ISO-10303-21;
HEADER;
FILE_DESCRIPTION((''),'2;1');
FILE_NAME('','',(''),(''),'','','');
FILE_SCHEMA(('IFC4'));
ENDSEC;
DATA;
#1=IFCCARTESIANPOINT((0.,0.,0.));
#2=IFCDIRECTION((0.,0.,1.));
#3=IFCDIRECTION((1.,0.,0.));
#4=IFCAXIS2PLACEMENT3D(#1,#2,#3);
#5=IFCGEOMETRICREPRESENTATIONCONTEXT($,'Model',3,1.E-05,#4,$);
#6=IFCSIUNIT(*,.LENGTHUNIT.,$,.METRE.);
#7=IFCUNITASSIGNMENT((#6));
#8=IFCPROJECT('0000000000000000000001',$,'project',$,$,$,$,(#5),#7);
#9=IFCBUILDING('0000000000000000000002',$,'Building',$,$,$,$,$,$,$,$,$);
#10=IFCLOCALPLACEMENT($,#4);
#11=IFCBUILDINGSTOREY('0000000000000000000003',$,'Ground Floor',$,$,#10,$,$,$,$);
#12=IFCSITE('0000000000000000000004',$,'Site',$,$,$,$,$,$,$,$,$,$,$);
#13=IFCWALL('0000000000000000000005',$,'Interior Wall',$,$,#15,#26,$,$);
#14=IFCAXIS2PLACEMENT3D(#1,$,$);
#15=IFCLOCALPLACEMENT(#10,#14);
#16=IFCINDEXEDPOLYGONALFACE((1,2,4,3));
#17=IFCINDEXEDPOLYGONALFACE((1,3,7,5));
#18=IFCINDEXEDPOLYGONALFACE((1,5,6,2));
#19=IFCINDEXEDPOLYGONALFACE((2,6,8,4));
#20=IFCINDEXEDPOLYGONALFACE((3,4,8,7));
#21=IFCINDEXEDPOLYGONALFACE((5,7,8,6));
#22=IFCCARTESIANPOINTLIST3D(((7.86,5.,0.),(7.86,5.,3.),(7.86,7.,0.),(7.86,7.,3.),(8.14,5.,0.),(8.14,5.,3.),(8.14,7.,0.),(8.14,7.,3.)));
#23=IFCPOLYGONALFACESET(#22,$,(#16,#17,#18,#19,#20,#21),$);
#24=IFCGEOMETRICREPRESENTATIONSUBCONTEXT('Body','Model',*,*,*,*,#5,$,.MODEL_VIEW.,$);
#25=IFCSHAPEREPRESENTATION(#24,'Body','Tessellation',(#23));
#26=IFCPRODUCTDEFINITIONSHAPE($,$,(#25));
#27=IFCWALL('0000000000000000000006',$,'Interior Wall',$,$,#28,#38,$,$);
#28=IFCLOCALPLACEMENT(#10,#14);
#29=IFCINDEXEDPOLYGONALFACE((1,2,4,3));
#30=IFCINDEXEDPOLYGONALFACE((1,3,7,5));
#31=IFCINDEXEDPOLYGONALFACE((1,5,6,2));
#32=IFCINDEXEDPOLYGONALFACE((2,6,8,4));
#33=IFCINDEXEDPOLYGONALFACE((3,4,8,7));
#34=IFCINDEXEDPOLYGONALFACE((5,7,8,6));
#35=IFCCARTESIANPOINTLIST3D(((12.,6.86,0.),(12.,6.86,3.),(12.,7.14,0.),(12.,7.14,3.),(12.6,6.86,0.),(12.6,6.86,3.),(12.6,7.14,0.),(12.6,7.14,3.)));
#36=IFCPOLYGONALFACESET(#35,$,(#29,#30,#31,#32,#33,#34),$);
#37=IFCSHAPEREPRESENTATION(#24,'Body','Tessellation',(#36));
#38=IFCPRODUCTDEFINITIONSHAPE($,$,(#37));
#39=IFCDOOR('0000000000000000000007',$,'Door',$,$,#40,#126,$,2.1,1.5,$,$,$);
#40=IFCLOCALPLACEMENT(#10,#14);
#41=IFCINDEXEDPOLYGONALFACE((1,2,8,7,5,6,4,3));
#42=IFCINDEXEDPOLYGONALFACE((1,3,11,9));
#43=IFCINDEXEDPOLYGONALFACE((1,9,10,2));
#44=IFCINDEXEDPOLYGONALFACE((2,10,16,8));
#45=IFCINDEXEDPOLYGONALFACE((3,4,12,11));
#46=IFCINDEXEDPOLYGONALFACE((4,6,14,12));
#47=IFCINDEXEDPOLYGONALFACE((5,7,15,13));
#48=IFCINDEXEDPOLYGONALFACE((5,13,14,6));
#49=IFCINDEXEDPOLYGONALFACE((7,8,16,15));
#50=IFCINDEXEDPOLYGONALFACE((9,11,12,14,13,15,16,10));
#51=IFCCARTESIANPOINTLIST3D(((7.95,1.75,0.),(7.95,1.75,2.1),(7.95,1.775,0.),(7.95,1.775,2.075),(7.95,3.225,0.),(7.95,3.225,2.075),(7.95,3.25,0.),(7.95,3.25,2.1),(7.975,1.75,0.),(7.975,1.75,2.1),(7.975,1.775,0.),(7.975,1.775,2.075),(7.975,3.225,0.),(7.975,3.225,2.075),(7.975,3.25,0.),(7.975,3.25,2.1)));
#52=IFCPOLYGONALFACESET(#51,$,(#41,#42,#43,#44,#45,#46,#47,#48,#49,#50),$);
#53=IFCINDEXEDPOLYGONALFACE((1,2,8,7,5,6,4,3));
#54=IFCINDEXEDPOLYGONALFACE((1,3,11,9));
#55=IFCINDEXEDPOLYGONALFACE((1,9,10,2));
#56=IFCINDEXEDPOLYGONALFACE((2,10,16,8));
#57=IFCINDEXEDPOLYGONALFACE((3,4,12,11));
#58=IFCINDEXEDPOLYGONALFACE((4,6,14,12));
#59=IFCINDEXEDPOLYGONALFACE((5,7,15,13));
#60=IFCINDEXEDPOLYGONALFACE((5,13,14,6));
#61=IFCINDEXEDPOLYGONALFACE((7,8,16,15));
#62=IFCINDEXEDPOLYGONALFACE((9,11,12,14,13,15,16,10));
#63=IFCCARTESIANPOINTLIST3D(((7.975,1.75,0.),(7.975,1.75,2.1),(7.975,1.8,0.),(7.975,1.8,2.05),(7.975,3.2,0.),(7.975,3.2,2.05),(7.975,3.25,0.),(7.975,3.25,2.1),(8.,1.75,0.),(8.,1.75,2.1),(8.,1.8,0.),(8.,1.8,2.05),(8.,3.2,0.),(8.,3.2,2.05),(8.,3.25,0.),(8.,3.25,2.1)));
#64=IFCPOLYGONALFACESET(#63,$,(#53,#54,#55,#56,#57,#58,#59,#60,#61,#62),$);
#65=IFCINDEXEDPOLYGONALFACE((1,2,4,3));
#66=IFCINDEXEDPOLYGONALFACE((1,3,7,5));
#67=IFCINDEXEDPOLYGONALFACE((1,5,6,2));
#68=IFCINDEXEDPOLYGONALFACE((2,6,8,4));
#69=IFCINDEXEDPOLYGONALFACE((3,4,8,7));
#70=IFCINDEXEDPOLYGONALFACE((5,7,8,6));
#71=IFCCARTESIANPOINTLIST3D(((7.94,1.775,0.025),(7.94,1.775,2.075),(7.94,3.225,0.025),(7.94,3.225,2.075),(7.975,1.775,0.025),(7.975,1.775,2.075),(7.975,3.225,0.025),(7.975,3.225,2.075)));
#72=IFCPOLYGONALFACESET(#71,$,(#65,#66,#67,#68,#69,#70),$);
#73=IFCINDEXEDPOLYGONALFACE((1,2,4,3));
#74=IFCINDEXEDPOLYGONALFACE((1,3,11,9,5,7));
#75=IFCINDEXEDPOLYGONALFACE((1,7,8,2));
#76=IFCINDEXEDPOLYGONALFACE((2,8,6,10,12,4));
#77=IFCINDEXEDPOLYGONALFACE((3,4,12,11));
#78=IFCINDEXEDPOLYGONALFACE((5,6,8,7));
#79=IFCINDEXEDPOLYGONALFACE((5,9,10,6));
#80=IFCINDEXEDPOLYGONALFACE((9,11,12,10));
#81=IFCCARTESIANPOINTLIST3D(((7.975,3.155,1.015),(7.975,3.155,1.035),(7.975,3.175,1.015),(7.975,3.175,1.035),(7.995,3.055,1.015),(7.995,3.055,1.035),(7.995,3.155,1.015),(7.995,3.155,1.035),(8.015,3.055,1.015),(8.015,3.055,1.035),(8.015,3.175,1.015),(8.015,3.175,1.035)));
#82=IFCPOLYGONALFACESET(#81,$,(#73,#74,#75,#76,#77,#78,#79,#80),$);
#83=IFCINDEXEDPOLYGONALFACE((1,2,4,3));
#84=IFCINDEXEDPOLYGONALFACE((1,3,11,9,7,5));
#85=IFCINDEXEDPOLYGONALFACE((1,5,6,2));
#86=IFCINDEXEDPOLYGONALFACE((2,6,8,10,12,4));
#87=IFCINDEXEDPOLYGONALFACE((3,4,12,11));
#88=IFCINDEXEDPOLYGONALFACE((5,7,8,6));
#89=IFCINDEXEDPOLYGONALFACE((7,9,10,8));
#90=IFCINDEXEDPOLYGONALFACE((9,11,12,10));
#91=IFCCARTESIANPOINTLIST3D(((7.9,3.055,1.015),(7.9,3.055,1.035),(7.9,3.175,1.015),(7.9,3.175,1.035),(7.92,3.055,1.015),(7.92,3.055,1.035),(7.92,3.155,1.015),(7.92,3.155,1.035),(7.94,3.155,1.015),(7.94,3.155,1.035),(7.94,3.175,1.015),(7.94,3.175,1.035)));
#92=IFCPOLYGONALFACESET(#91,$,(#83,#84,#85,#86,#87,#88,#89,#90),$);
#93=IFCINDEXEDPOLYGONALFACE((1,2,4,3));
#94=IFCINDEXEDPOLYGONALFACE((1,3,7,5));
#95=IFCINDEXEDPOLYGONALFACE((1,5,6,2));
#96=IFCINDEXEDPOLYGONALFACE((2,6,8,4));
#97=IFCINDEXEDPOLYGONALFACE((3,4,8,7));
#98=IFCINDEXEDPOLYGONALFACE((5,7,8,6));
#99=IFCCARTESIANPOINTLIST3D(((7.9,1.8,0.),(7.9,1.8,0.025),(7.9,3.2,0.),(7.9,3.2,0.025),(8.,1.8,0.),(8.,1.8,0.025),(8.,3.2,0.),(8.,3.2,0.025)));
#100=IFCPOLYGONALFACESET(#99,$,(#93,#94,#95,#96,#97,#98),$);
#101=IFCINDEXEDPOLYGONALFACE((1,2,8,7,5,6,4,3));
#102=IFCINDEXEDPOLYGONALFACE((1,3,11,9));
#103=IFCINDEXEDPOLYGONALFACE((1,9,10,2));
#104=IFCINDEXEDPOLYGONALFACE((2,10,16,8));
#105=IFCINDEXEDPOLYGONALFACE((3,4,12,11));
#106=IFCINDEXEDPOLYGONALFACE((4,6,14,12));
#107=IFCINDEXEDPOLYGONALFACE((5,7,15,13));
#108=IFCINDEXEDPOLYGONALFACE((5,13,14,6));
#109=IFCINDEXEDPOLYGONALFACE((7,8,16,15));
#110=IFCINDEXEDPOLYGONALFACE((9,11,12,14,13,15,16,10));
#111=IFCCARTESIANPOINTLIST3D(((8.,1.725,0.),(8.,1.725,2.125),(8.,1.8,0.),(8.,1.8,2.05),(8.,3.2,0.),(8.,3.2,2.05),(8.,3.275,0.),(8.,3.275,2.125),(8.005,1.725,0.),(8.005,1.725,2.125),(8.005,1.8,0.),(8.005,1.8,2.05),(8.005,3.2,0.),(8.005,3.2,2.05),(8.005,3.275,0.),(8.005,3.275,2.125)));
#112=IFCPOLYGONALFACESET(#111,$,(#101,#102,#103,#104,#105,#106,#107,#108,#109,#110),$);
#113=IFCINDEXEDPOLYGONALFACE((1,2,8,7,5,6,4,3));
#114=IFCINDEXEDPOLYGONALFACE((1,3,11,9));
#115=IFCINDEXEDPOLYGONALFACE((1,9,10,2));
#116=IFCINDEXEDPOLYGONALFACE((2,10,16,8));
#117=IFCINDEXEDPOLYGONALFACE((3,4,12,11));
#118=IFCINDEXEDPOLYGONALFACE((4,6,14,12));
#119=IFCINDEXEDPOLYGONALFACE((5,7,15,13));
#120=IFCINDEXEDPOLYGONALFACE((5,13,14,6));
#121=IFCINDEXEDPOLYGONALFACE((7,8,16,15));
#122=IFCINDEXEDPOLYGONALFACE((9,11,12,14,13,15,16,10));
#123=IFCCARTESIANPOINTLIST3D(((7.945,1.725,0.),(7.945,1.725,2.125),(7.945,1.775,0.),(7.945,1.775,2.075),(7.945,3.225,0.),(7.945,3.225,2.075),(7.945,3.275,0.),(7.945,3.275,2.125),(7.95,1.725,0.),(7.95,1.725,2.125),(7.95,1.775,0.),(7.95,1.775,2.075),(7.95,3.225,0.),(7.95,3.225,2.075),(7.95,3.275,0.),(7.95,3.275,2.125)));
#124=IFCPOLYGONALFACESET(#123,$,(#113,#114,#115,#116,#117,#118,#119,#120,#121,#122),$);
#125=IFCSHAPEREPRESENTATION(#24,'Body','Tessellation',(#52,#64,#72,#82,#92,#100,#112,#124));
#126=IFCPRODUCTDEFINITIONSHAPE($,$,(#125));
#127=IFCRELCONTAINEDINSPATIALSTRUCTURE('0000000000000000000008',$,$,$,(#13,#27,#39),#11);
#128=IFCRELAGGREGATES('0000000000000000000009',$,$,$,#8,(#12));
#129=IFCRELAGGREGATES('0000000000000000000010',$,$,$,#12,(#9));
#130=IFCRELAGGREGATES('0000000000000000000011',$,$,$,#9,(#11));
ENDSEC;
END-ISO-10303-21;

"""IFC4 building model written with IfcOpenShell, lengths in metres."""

from ifc_helpers import new_model, si_unit, frame, origin_with_axes, place, context, subcontext, project, spatial, line, indexed_curve, outline, extrude, element, save


model = new_model("IFC4")

# Units and contexts
model_context = context("Model", 3, precision=1e-05, world=origin_with_axes())
body_context = subcontext(model_context, "Body", "Model", "MODEL_VIEW")
ifc_project = project(units=[si_unit("LENGTHUNIT", "METRE")], contexts=[model_context])

# Site, building, storey
site = spatial("IfcSite", under=ifc_project, Name="Site")
building = spatial("IfcBuilding", under=site, Name="Building")
storey_placement = place(None, origin_with_axes())
storey = spatial("IfcBuildingStorey", under=building, at=storey_placement, Name="Ground Floor")

# Walls
wall_1_placement = place(storey_placement, frame((8.0, 7.0, 0.0), z_axis=(0.0, 0.0, 1.0), x_axis=(0.0, -1.0, 0.0)))
element("IfcWall", 1, at=wall_1_placement, inside=storey, Name="Interior Wall", context=body_context, shape_type="SweptSolid", body=[
    extrude(outline(indexed_curve([(0.0, 0.0), (0.0, 0.28), (2.0, 0.28), (2.0, 0.0), (0.0, 0.0)], self_intersect=False)), frame((0.0, -0.14, 0.0), z_axis=(0.0, 0.0, 1.0), x_axis=(1.0, 0.0, 0.0)), (0.0, 0.0, 1.0), 3.0),
])
wall_2_placement = place(storey_placement, frame((12.6, 7.0, 0.0), z_axis=(0.0, 0.0, 1.0), x_axis=(-1.0, 0.0, 0.0)))
element("IfcWall", 2, at=wall_2_placement, inside=storey, Name="Interior Wall", context=body_context, shape_type="SweptSolid", body=[
    extrude(outline(indexed_curve([(0.0, 0.0), (0.0, 0.28), (0.6, 0.28), (0.6, 0.0), (0.0, 0.0)], self_intersect=False)), frame((0.0, -0.14, 0.0), z_axis=(0.0, 0.0, 1.0), x_axis=(1.0, 0.0, 0.0)), (0.0, 0.0, 1.0), 3.0),
])

# Door
door_1_placement = place(storey_placement, frame((8.0, 1.75, 0.0), z_axis=(0.0, 0.0, 1.0), x_axis=(0.0, 1.0, 0.0)))
element("IfcDoor", 3, at=door_1_placement, inside=storey, Name="Door", OverallHeight=2.1, OverallWidth=1.5, context=body_context, shape_type="SweptSolid", body=[
    extrude(outline(indexed_curve([(0.0, 0.0), (0.0, 2.1), (1.5, 2.1), (1.5, 0.0), (1.475, 0.0), (1.475, 2.075), (0.025, 2.075), (0.025, 0.0)], segments=[line(1, 2, 3, 4, 5, 6, 7, 8, 1)])), frame((0.0, 0.025, 0.0), z_axis=(0.0, -1.0, 0.0), x_axis=(1.0, 0.0, 0.0)), (0.0, 0.0, -1.0), 0.025),
    extrude(outline(indexed_curve([(0.0, 0.0), (0.0, 2.1), (1.5, 2.1), (1.5, 0.0), (1.45, 0.0), (1.45, 2.05), (0.05, 2.05), (0.05, 0.0)], segments=[line(1, 2, 3, 4, 5, 6, 7, 8, 1)])), frame((0.0, 0.0, 0.0), z_axis=(0.0, -1.0, 0.0), x_axis=(1.0, 0.0, 0.0)), (0.0, 0.0, -1.0), 0.025),
    extrude(outline(indexed_curve([(0.0, 0.0), (1.45, 0.0), (1.45, 0.035), (0.0, 0.035)], segments=[line(1, 2, 3, 4, 1)])), frame((0.025, 0.025, 0.025), z_axis=(0.0, 0.0, 1.0), x_axis=(1.0, 0.0, 0.0)), (0.0, 0.0, 1.0), 2.05),
    extrude(outline(indexed_curve([(0.0, 0.0), (0.0, -0.04), (-0.12, -0.04), (-0.12, -0.02), (-0.02, -0.02), (-0.02, 0.0)], segments=[line(1, 2, 3, 4, 5, 6, 1)])), frame((1.425, 0.025, 1.015), z_axis=(0.0, 0.0, 1.0), x_axis=(1.0, 0.0, 0.0)), (0.0, 0.0, 1.0), 0.02),
    extrude(outline(indexed_curve([(0.0, 0.0), (0.0, 0.04), (-0.12, 0.04), (-0.12, 0.02), (-0.02, 0.02), (-0.02, 0.0)], segments=[line(1, 2, 3, 4, 5, 6, 1)])), frame((1.425, 0.06, 1.015), z_axis=(0.0, 0.0, 1.0), x_axis=(1.0, 0.0, 0.0)), (0.0, 0.0, 1.0), 0.02),
    extrude(outline(indexed_curve([(0.0, 0.0), (1.4, 0.0), (1.4, 0.1), (0.0, 0.1)], segments=[line(1, 2, 3, 4, 1)])), frame((0.05, 0.0, 0.0), z_axis=(0.0, 0.0, 1.0), x_axis=(1.0, 0.0, 0.0)), (0.0, 0.0, 1.0), 0.025),
    extrude(outline(indexed_curve([(0.0, 0.0), (0.0, 2.125), (1.55, 2.125), (1.55, 0.0), (1.475, 0.0), (1.475, 2.05), (0.075, 2.05), (0.075, 0.0)], segments=[line(1, 2, 3, 4, 5, 6, 7, 8, 1)])), frame((-0.025, -0.005, 0.0), z_axis=(0.0, -1.0, 0.0), x_axis=(1.0, 0.0, 0.0)), (0.0, 0.0, -1.0), 0.005),
    extrude(outline(indexed_curve([(0.0, 0.0), (0.0, 2.125), (1.55, 2.125), (1.55, 0.0), (1.5, 0.0), (1.5, 2.075), (0.05, 2.075), (0.05, 0.0)], segments=[line(1, 2, 3, 4, 5, 6, 7, 8, 1)])), frame((-0.025, 0.05, 0.0), z_axis=(0.0, -1.0, 0.0), x_axis=(1.0, 0.0, 0.0)), (0.0, 0.0, -1.0), 0.005),
])

save(model, "model.ifc")
